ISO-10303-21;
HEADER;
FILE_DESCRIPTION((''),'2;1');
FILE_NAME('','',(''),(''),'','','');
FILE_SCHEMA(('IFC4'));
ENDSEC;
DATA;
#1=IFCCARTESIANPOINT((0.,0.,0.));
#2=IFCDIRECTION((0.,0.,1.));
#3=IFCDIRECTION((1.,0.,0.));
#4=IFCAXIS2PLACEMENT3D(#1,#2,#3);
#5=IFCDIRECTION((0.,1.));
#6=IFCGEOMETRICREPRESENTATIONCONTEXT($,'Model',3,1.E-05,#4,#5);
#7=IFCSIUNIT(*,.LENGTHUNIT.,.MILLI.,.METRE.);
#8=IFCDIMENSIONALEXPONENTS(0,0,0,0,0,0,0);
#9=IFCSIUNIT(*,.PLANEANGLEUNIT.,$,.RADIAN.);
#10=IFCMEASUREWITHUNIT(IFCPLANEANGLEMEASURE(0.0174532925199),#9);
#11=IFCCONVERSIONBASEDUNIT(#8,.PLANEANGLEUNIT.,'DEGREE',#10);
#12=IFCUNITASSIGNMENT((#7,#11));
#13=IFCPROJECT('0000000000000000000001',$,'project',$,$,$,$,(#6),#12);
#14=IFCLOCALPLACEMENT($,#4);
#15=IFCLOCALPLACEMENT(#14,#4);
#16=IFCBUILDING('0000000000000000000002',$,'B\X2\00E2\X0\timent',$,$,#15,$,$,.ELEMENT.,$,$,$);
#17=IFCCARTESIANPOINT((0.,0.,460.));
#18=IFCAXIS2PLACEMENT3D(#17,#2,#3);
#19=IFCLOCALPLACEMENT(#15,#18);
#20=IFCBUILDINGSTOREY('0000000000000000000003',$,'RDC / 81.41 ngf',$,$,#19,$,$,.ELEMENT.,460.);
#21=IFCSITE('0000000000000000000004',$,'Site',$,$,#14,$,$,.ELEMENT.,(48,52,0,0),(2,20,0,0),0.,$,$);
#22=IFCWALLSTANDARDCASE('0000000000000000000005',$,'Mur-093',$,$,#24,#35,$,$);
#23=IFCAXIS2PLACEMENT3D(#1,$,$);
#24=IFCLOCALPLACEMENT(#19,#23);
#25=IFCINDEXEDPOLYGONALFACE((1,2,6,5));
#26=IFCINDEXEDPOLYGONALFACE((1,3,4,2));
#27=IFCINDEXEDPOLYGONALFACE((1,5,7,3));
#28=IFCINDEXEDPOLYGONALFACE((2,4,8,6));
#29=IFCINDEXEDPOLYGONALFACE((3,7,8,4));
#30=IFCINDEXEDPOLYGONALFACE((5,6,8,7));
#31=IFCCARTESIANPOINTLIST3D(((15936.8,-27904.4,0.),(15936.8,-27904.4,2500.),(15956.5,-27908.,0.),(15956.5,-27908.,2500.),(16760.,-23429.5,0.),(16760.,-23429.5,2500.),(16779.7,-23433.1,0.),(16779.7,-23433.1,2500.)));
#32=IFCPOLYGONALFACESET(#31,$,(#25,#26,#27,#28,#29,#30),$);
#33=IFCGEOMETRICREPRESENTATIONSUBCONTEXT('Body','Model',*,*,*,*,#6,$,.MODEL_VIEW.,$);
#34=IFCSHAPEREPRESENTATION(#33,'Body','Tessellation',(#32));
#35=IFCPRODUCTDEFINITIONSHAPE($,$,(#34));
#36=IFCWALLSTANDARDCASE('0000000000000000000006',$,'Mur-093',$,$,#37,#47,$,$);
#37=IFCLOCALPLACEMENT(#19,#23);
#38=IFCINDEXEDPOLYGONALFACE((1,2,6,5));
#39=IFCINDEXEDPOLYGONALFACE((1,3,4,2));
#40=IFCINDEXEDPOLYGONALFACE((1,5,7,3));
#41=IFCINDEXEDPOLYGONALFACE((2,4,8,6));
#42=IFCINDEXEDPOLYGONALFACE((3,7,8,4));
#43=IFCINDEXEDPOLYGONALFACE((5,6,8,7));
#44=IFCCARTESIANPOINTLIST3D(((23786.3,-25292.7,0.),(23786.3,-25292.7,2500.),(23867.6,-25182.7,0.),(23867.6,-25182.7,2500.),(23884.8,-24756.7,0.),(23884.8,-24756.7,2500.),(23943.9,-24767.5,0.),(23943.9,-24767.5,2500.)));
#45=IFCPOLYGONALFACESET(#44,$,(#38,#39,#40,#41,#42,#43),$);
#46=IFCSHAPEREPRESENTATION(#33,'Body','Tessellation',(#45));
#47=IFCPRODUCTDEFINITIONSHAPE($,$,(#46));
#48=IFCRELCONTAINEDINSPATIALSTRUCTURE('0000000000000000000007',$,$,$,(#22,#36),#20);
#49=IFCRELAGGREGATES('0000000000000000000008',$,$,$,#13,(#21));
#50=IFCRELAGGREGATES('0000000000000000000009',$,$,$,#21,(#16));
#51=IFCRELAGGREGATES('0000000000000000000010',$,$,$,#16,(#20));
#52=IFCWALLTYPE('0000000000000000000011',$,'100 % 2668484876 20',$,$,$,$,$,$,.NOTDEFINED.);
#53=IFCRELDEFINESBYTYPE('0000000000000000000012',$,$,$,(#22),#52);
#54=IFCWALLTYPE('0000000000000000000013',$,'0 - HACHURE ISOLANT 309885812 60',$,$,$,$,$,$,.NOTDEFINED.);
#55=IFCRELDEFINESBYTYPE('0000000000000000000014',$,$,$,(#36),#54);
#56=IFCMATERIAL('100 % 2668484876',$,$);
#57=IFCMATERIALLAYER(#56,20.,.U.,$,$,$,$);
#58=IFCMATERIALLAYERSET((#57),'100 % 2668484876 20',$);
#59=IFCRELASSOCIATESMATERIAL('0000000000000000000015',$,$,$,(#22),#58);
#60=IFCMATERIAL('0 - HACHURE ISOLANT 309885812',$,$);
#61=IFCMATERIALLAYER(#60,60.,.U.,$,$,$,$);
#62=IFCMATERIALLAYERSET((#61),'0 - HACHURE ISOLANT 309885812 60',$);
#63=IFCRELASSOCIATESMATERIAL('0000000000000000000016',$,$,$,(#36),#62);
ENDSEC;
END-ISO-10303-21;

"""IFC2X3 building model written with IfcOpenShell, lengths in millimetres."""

from ifc_helpers import new_model, entity, si_unit, converted_unit, direction, frame, origin_with_axes, place, context, subcontext, project, spatial, polyline, outline, extrude, material, layer, layer_set, layer_usage, type_object, element, save


model = new_model("IFC2X3")

# Units and contexts
model_context = context("Model", 3, precision=1e-05, world=origin_with_axes(), true_north=direction((0.0, 1.0)))
body_context = subcontext(model_context, "Body", "Model", "MODEL_VIEW")
ifc_project = project(units=[si_unit("LENGTHUNIT", "METRE", prefix="MILLI"), converted_unit("PLANEANGLEUNIT", "DEGREE", entity("IfcPlaneAngleMeasure", 0.0174532925199), si_unit("PLANEANGLEUNIT", "RADIAN"), dimensions=[0, 0, 0, 0, 0, 0, 0])], contexts=[model_context])

# Site, building, storey
site_placement = place(None, origin_with_axes())
site = spatial("IfcSite", under=ifc_project, at=site_placement, Name="Site", CompositionType="ELEMENT", RefLatitude=(48, 52, 0, 0), RefLongitude=(2, 20, 0, 0), RefElevation=0.0)
building_placement = place(site_placement, origin_with_axes())
building = spatial("IfcBuilding", under=site, at=building_placement, Name="Bâtiment", CompositionType="ELEMENT")
storey_placement = place(building_placement, frame((0.0, 0.0, 460.0), z_axis=(0.0, 0.0, 1.0), x_axis=(1.0, 0.0, 0.0)))
storey = spatial("IfcBuildingStorey", under=building, at=storey_placement, Name="RDC / 81.41 ngf", CompositionType="ELEMENT", Elevation=460.0)

# Shared definitions
ifc_material_1 = material(Name="100 % 2668484876")

# Shared definitions
ifc_material_2 = material(Name="0 - HACHURE ISOLANT 309885812")

# Walls
ifc_layer_1 = layer(ifc_material_1, 20.0, ventilated="UNKNOWN")
ifc_layer_set_1 = layer_set([ifc_layer_1], Name="100 % 2668484876 20")
ifc_layer_usage_1 = layer_usage(ifc_layer_set_1, "AXIS2", "POSITIVE", -20.0)
wall_type_1 = type_object("IfcWallType", Name="100 % 2668484876 20", PredefinedType="NOTDEFINED")
wall_1_placement = place(storey_placement, frame((15936.8, -27904.4, 0.0), z_axis=(0.0, 0.0, 1.0), x_axis=(0.180929, 0.983496, 0.0)))
element("IfcWallStandardCase", 1, at=wall_1_placement, inside=storey, type_object=wall_type_1, material=ifc_layer_usage_1, Name="Mur-093", context=body_context, shape_type="SweptSolid", body=[
    extrude(outline(polyline([(0.0, -20.0), (4550.0, -20.0), (4550.0, 0.0), (0.0, 0.0), (0.0, -20.0)])), origin_with_axes(), (0.0, 0.0, 1.0), 2500.0),
])
ifc_layer_2 = layer(ifc_material_2, 60.0, ventilated="UNKNOWN")
ifc_layer_set_2 = layer_set([ifc_layer_2], Name="0 - HACHURE ISOLANT 309885812 60")
ifc_layer_usage_2 = layer_usage(ifc_layer_set_2, "AXIS2", "NEGATIVE", 60.0)
wall_type_2 = type_object("IfcWallType", Name="0 - HACHURE ISOLANT 309885812 60", PredefinedType="NOTDEFINED")
wall_2_placement = place(storey_placement, frame((23884.8, -24756.7, 0.0), z_axis=(0.0, 0.0, 1.0), x_axis=(-0.180731, -0.983533, 0.0)))
element("IfcWallStandardCase", 2, at=wall_2_placement, inside=storey, type_object=wall_type_2, material=ifc_layer_usage_2, Name="Mur-093", context=body_context, shape_type="SweptSolid", body=[
    extrude(outline(polyline([(0.0, 0.0), (545.0, 0.0), (422.1, 60.0), (0.0, 60.0), (0.0, 0.0)])), origin_with_axes(), (0.0, 0.0, 1.0), 2500.0),
])

save(model, "model.ifc")
